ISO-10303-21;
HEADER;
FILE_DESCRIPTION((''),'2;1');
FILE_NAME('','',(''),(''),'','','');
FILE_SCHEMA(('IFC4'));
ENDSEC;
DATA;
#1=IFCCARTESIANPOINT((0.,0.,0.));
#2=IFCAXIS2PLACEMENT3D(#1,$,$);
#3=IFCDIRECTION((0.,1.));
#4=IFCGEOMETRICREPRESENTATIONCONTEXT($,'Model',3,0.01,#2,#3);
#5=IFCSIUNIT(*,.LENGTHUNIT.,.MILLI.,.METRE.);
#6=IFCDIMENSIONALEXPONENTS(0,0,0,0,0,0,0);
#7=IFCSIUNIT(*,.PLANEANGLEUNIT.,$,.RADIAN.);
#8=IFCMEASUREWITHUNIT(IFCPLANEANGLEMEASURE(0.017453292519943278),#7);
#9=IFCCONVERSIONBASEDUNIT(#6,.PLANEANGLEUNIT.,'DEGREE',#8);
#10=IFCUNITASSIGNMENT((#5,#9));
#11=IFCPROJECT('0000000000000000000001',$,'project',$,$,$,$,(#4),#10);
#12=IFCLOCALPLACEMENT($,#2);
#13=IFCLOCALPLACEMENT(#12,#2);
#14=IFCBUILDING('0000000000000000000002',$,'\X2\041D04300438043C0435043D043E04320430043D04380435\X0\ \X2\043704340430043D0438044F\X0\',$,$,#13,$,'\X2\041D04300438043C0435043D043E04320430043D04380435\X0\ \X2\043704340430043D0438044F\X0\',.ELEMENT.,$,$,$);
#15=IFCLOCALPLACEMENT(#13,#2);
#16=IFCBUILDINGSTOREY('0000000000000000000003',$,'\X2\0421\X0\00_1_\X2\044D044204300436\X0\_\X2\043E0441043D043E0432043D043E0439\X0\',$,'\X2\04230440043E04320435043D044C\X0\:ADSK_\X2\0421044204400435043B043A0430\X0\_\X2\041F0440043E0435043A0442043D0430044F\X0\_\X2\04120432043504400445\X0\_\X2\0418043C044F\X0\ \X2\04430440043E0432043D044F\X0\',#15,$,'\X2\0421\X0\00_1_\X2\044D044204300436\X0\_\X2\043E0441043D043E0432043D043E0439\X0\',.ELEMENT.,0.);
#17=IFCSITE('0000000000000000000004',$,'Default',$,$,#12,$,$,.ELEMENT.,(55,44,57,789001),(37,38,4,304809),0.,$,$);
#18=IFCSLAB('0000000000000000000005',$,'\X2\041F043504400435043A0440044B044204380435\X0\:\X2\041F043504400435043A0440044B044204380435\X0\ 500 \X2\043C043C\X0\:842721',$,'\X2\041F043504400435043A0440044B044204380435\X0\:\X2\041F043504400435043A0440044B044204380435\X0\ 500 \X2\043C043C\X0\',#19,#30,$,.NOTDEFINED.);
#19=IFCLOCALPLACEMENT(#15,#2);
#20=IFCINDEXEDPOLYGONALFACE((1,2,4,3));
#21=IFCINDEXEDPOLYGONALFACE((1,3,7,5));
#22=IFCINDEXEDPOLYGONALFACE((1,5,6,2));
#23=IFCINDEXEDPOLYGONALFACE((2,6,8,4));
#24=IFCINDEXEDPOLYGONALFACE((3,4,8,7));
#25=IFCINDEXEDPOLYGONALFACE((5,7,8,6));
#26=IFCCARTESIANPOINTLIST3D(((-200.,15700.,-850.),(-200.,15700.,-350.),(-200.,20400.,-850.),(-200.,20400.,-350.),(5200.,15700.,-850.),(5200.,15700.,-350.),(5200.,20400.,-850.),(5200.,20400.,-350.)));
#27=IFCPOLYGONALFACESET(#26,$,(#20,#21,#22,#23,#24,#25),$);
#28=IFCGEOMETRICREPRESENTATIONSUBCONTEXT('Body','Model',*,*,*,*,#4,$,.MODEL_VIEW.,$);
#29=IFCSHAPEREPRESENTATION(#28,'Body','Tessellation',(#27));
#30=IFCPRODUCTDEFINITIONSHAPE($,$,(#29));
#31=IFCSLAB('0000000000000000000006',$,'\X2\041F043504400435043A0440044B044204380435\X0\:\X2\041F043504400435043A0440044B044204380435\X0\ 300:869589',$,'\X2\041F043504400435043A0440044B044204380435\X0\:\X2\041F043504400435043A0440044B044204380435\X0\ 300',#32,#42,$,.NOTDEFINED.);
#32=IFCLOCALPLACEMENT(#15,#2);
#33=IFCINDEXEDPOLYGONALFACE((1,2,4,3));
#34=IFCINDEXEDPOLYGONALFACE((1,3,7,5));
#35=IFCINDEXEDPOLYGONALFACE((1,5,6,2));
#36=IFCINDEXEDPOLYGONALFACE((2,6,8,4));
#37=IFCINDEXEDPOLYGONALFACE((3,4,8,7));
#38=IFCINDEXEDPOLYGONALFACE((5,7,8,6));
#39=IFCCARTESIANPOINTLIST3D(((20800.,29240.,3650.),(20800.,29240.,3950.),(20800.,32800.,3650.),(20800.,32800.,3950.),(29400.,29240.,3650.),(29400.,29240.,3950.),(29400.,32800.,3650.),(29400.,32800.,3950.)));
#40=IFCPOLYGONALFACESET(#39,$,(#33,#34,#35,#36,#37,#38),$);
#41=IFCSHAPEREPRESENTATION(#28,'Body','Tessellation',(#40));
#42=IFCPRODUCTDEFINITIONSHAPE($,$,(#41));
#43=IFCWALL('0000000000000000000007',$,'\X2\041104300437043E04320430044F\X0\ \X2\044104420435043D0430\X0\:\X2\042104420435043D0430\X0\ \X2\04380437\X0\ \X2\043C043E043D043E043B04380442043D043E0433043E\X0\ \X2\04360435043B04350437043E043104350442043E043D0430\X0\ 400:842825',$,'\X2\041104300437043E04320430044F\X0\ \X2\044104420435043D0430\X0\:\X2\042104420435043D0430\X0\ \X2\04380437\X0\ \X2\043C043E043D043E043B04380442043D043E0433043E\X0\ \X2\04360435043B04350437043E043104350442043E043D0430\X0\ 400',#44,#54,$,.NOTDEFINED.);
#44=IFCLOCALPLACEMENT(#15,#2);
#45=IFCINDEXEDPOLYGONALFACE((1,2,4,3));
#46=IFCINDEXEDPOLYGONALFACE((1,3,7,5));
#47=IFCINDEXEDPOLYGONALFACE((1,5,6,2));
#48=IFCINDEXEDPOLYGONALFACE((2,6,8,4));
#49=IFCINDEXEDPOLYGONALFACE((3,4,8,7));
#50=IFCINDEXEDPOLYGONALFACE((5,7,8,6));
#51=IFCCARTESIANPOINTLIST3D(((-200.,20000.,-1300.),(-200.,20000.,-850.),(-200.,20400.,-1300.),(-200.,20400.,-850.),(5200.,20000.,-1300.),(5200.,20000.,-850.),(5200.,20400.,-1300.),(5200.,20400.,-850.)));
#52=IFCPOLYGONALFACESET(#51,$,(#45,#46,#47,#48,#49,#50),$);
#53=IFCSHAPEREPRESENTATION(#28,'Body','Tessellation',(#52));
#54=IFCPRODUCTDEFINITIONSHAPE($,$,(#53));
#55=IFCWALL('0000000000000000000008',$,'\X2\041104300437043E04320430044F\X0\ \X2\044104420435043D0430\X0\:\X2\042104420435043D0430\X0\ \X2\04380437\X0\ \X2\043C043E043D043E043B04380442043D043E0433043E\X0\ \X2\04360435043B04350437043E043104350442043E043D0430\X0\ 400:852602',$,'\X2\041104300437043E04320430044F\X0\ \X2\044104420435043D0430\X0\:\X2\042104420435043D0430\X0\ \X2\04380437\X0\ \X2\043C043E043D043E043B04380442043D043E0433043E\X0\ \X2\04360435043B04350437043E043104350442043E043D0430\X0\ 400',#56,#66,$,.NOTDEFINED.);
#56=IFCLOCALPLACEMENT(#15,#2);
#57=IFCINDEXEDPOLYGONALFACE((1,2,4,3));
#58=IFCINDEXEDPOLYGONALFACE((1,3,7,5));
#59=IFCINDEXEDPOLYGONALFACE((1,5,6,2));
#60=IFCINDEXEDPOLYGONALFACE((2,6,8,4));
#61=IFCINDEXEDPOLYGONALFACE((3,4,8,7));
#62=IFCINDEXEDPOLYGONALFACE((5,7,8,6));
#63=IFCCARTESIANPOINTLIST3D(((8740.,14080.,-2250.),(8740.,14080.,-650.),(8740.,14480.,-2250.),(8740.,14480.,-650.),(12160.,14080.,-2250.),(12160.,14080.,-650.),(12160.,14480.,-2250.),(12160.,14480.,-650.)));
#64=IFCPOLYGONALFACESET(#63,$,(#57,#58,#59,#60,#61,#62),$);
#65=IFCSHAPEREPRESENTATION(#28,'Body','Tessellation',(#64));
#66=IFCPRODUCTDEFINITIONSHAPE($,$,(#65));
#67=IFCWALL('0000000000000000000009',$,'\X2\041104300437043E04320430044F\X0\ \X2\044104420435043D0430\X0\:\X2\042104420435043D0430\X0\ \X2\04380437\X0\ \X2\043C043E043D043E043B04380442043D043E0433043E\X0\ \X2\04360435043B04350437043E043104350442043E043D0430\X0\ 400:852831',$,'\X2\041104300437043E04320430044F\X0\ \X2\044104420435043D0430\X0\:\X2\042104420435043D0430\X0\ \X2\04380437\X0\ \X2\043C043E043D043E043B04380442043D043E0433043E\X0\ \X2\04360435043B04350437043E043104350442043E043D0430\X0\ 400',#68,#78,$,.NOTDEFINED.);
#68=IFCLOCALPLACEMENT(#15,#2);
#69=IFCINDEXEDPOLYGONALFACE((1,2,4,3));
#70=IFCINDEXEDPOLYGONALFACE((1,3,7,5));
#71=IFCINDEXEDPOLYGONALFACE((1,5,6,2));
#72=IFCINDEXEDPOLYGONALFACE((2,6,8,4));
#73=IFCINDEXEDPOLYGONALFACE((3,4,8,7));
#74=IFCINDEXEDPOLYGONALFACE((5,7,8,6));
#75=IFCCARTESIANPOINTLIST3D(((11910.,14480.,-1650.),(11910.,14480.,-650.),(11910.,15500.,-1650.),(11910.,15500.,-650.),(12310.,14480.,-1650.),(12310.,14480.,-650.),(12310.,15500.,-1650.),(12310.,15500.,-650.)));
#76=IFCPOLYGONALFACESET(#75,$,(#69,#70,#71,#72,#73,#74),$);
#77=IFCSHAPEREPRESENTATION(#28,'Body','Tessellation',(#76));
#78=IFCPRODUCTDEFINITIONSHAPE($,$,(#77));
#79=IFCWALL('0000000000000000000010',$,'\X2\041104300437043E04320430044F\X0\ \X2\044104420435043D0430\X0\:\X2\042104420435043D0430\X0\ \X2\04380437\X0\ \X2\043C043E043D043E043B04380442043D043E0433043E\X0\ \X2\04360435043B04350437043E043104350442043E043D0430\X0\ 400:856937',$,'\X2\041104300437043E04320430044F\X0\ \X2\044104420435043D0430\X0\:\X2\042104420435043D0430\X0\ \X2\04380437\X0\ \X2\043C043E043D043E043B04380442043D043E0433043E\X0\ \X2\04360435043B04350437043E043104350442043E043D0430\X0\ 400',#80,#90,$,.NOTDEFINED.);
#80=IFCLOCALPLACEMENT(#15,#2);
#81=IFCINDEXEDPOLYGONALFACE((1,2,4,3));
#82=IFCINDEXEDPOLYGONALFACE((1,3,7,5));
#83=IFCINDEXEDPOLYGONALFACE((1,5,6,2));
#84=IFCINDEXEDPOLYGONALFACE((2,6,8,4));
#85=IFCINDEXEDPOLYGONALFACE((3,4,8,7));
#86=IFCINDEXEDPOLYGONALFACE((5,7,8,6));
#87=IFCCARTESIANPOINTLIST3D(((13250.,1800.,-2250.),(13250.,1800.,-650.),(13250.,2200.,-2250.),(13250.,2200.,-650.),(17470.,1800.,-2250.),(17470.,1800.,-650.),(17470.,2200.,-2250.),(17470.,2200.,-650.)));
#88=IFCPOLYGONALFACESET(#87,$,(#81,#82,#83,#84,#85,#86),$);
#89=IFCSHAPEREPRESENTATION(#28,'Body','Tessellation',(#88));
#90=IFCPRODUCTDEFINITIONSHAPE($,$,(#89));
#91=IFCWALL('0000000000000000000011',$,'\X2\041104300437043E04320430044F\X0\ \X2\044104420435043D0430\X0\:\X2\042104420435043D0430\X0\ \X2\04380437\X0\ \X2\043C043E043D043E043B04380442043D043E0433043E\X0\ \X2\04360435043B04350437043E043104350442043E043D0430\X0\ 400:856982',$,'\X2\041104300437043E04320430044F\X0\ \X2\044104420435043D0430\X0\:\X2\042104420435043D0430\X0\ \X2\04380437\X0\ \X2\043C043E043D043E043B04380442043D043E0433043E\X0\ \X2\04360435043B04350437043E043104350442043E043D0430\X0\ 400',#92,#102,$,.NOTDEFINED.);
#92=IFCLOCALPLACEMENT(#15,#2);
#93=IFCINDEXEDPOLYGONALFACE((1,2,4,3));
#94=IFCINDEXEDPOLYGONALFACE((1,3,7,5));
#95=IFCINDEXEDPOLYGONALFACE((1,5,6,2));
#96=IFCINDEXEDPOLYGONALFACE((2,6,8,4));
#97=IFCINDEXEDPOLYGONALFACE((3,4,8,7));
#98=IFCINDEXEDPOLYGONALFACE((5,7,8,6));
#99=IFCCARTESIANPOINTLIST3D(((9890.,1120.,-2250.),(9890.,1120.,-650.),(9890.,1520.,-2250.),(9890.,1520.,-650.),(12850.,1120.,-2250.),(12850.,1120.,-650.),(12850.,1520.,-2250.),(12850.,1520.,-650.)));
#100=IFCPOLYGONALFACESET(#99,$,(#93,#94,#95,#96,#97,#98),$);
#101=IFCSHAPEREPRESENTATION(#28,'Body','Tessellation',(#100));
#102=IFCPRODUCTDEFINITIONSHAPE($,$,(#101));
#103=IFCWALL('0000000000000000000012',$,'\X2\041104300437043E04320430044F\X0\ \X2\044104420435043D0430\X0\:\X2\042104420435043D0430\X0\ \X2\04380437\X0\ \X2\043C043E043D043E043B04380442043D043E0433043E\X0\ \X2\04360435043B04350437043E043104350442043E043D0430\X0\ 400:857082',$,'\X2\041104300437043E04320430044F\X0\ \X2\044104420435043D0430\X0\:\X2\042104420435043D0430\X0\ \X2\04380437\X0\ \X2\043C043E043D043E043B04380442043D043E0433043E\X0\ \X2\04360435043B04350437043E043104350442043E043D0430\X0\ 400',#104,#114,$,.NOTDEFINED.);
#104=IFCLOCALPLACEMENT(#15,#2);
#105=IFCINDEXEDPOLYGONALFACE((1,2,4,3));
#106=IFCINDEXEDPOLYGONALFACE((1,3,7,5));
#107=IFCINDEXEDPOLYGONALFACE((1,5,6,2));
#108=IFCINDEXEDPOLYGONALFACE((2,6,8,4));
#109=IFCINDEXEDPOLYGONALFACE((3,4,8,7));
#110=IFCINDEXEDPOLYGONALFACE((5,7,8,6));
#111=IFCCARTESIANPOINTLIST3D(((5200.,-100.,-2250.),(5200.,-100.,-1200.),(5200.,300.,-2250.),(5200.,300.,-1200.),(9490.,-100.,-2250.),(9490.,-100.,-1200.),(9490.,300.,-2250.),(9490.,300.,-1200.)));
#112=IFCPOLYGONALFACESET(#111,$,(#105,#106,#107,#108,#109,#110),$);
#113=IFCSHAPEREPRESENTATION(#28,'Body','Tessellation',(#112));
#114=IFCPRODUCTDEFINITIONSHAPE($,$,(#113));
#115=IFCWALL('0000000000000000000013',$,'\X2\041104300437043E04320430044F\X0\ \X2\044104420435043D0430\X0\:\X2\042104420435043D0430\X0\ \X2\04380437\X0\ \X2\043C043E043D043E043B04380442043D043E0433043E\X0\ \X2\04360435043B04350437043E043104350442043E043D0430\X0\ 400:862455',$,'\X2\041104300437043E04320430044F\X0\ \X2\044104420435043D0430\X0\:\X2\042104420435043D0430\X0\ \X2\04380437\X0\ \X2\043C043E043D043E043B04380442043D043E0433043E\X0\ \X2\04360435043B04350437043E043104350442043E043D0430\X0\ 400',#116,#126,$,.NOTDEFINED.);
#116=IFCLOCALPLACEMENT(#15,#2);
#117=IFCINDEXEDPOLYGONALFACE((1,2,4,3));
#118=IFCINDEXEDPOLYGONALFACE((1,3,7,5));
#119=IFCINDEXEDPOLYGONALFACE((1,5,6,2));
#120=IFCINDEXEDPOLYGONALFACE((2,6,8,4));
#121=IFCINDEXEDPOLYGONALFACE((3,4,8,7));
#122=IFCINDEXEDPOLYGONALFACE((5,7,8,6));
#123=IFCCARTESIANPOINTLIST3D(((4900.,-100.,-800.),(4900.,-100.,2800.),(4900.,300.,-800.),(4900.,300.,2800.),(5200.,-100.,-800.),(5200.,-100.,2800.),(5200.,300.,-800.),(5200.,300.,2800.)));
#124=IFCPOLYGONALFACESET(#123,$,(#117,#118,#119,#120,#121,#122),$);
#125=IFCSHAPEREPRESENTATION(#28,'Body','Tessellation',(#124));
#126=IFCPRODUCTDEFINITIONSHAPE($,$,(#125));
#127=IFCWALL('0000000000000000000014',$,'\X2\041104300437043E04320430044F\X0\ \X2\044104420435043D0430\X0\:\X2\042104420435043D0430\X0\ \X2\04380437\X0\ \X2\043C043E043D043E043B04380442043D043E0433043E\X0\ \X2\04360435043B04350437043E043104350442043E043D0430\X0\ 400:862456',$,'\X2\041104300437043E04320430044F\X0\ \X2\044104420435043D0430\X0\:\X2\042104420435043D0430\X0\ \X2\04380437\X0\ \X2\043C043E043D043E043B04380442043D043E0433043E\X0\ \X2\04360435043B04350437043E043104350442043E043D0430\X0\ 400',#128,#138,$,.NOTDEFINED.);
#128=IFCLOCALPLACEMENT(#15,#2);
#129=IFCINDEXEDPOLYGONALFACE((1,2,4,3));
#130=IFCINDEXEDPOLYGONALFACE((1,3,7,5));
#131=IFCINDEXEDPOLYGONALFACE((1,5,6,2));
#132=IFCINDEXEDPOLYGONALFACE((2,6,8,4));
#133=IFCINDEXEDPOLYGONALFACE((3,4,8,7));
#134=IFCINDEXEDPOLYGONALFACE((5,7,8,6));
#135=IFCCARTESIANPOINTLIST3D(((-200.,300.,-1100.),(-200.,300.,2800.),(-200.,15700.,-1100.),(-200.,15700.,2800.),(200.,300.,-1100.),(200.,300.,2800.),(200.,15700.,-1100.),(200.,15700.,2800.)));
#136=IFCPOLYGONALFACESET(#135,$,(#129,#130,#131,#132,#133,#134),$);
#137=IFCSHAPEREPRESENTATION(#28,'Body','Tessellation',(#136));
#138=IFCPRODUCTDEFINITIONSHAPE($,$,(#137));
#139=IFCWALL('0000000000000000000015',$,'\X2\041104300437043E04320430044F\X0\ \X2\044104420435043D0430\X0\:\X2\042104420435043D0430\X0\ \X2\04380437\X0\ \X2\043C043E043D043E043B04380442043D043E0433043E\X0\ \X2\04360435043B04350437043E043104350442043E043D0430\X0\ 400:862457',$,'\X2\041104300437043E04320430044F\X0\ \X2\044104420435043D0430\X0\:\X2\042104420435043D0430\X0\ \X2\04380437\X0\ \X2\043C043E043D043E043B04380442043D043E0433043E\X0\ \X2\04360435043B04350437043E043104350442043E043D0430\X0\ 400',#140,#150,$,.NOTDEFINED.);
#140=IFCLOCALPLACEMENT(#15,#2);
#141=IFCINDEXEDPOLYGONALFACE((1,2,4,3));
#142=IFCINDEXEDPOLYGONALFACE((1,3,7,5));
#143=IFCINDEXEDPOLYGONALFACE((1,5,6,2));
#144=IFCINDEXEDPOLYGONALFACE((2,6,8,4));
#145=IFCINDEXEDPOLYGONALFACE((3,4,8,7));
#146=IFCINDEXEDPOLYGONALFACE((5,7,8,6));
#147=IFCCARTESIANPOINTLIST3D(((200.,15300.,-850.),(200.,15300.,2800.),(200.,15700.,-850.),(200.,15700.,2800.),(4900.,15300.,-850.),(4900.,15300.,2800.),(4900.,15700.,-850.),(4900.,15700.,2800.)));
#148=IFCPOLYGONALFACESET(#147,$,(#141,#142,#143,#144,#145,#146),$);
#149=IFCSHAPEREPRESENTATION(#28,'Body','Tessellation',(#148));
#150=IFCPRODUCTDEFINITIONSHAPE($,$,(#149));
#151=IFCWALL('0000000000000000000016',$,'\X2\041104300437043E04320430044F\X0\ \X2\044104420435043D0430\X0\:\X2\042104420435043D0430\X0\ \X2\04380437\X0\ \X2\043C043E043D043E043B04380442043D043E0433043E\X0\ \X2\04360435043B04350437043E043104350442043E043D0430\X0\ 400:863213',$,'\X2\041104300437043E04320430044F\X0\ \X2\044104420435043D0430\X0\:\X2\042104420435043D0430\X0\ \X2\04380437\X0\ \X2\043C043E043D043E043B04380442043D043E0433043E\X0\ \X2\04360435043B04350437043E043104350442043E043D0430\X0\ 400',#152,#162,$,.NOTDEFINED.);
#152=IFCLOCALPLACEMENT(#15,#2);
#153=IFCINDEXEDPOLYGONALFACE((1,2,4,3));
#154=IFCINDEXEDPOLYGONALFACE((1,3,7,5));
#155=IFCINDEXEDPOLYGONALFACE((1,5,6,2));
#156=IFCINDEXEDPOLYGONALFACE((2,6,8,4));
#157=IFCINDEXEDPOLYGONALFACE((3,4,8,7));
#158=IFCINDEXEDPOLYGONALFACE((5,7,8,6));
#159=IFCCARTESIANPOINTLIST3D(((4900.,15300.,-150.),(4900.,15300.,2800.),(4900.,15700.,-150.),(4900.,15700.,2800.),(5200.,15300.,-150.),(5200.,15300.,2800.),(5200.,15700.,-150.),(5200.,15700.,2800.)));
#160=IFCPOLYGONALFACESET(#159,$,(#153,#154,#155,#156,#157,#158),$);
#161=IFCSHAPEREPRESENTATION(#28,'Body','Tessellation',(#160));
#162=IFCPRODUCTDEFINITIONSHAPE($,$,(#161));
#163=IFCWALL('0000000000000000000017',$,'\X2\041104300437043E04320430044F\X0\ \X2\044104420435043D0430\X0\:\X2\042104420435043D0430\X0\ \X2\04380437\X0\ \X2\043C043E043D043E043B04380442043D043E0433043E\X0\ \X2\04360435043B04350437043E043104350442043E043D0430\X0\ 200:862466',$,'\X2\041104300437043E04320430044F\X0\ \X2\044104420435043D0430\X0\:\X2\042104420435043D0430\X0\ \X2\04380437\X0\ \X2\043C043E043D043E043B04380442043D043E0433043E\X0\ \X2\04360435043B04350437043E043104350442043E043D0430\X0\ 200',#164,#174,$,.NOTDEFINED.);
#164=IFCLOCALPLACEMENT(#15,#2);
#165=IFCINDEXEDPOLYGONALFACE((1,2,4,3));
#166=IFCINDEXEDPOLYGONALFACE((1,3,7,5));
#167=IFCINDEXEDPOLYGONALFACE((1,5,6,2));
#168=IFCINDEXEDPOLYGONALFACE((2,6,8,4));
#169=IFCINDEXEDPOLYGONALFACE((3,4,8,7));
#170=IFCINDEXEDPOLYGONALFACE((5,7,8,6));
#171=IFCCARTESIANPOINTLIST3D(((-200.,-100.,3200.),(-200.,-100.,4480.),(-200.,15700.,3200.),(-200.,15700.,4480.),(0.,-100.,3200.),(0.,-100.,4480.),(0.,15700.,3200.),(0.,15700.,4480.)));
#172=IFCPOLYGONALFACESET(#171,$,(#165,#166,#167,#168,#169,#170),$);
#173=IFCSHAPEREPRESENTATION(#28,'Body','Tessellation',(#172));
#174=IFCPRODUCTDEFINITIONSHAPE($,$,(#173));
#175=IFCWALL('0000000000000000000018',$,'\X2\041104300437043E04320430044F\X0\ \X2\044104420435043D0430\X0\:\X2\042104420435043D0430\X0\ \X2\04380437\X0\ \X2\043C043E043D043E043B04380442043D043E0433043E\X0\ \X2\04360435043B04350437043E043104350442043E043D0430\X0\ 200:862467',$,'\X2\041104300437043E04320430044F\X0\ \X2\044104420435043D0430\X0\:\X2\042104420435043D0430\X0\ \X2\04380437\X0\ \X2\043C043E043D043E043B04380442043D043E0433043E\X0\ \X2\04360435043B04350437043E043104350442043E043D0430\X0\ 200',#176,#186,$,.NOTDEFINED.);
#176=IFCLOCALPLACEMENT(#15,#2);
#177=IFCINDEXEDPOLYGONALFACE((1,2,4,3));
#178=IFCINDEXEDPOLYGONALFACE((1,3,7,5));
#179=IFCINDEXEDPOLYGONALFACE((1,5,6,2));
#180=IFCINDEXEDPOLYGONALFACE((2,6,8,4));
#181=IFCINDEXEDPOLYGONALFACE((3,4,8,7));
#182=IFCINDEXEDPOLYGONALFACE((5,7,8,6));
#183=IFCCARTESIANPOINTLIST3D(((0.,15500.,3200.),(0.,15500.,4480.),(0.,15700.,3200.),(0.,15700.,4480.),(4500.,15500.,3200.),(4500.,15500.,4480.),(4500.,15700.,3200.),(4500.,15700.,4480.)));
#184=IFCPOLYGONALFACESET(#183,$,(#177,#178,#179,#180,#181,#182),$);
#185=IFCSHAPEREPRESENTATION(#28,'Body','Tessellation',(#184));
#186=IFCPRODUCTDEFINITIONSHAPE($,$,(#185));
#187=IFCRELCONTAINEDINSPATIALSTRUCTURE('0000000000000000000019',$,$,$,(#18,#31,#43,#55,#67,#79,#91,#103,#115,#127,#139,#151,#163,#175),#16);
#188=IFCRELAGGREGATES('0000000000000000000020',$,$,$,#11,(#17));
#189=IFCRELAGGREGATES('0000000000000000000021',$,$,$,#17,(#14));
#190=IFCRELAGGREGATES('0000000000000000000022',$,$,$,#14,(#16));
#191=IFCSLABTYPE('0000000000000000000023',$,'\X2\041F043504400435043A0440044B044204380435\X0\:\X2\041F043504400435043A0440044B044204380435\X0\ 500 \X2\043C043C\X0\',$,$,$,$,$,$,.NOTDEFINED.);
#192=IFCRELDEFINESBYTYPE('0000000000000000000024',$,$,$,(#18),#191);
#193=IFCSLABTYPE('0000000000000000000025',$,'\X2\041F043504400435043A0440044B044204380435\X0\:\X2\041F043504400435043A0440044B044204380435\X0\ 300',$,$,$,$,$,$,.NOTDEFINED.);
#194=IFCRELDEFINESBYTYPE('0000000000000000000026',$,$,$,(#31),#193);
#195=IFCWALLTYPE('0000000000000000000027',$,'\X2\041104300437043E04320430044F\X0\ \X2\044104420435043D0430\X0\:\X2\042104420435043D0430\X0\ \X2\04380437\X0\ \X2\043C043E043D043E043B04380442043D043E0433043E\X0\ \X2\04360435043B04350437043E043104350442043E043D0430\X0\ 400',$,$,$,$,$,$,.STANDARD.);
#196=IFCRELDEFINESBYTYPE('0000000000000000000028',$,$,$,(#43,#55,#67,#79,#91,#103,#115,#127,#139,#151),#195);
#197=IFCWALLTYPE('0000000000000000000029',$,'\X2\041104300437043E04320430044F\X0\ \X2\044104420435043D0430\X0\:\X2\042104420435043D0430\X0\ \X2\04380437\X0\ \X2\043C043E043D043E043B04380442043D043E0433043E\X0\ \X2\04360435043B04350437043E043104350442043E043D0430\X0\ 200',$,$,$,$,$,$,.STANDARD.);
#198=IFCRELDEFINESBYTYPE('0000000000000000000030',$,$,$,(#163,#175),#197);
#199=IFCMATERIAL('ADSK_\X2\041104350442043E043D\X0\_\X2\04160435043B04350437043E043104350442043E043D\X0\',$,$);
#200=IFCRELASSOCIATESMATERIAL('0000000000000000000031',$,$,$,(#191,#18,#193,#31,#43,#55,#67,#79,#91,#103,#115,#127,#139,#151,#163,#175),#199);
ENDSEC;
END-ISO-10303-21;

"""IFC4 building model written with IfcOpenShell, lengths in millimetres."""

from ifc_helpers import new_model, entity, si_unit, converted_unit, direction, frame, origin, place, context, subcontext, project, spatial, indexed_curve, outline, extrude, material, type_object, element, save


model = new_model("IFC4")

# Units and contexts
model_context = context("Model", 3, precision=0.01, world=origin(), true_north=direction((0.0, 1.0)))
body_context = subcontext(model_context, "Body", "Model", "MODEL_VIEW")
ifc_project = project(units=[si_unit("LENGTHUNIT", "METRE", prefix="MILLI"), converted_unit("PLANEANGLEUNIT", "DEGREE", entity("IfcPlaneAngleMeasure", 0.017453292519943278), si_unit("PLANEANGLEUNIT", "RADIAN"), dimensions=[0, 0, 0, 0, 0, 0, 0])], contexts=[model_context])

# Site, building, storey
site_placement = place(None, origin())
site = spatial("IfcSite", under=ifc_project, at=site_placement, Name="Default", CompositionType="ELEMENT", RefLatitude=(55, 44, 57, 789001), RefLongitude=(37, 38, 4, 304809), RefElevation=0.0)
building_placement = place(site_placement, origin())
building = spatial("IfcBuilding", under=site, at=building_placement, Name="Наименование здания", LongName="Наименование здания", CompositionType="ELEMENT")
storey_placement = place(building_placement, origin())
storey = spatial("IfcBuildingStorey", under=building, at=storey_placement, Name="С00_1_этаж_основной", ObjectType="Уровень:ADSK_Стрелка_Проектная_Вверх_Имя уровня", LongName="С00_1_этаж_основной", CompositionType="ELEMENT", Elevation=0.0)

# Slabs
ifc_material_1 = material(Name="ADSK_Бетон_Железобетон")
slab_type_1 = type_object("IfcSlabType", Name="Перекрытие:Перекрытие 500 мм", PredefinedType="NOTDEFINED", material=ifc_material_1)
slab_1_placement = place(storey_placement, origin())
element("IfcSlab", 1, at=slab_1_placement, inside=storey, type_object=slab_type_1, material=ifc_material_1, Name="Перекрытие:Перекрытие 500 мм:842721", ObjectType="Перекрытие:Перекрытие 500 мм", PredefinedType="NOTDEFINED", context=body_context, shape_type="SweptSolid", body=[
    extrude(outline(indexed_curve([(-2350.0, -2700.0), (2350.0, -2700.0), (2350.0, 2700.0), (-2350.0, 2700.0), (-2350.0, -2700.0)], self_intersect=False)), frame((2500.0, 18050.0, -350.0), z_axis=(0.0, 0.0, -1.0), x_axis=(0.0, 1.0, 0.0)), (0.0, 0.0, 1.0), 500.0),
])
slab_type_2 = type_object("IfcSlabType", Name="Перекрытие:Перекрытие 300", PredefinedType="NOTDEFINED", material=ifc_material_1)
slab_2_placement = place(storey_placement, origin())
element("IfcSlab", 2, at=slab_2_placement, inside=storey, type_object=slab_type_2, material=ifc_material_1, Name="Перекрытие:Перекрытие 300:869589", ObjectType="Перекрытие:Перекрытие 300", PredefinedType="NOTDEFINED", context=body_context, shape_type="SweptSolid", body=[
    extrude(outline(indexed_curve([(-1780.0, -4300.0), (1780.0, -4300.0), (1780.0, 4300.0), (-1780.0, 4300.0), (-1780.0, -4300.0)], self_intersect=False)), frame((25100.0, 31020.0, 3950.0), z_axis=(0.0, 0.0, -1.0), x_axis=(0.0, 1.0, 0.0)), (0.0, 0.0, 1.0), 300.0),
])

# Walls
wall_type_1 = type_object("IfcWallType", Name="Базовая стена:Стена из монолитного железобетона 400", PredefinedType="STANDARD")
wall_1_placement = place(storey_placement, frame((-200.0, 20200.0, -1300.0)))
element("IfcWall", 3, at=wall_1_placement, inside=storey, type_object=wall_type_1, material=ifc_material_1, Name="Базовая стена:Стена из монолитного железобетона 400:842825", ObjectType="Базовая стена:Стена из монолитного железобетона 400", PredefinedType="NOTDEFINED", context=body_context, shape_type="SweptSolid", body=[
    extrude(outline(indexed_curve([(5400.0, 200.0), (0.0, 200.0), (0.0, -200.0), (5400.0, -200.0), (5400.0, 200.0)], self_intersect=False)), origin(), (0.0, 0.0, 1.0), 450.0),
])
wall_2_placement = place(storey_placement, frame((12160.0, 14280.0, -2250.0), z_axis=(0.0, 0.0, 1.0), x_axis=(-1.0, 0.0, 0.0)))
element("IfcWall", 4, at=wall_2_placement, inside=storey, type_object=wall_type_1, material=ifc_material_1, Name="Базовая стена:Стена из монолитного железобетона 400:852602", ObjectType="Базовая стена:Стена из монолитного железобетона 400", PredefinedType="NOTDEFINED", context=body_context, shape_type="SweptSolid", body=[
    extrude(outline(indexed_curve([(3420.0, 200.0), (0.0, 200.0), (0.0, -200.0), (3420.0, -200.0), (3420.0, 200.0)], self_intersect=False)), origin(), (0.0, 0.0, 1.0), 1600.0),
])
wall_3_placement = place(storey_placement, frame((12110.0, 14480.0, -1650.0), z_axis=(0.0, 0.0, 1.0), x_axis=(0.0, 1.0, 0.0)))
element("IfcWall", 5, at=wall_3_placement, inside=storey, type_object=wall_type_1, material=ifc_material_1, Name="Базовая стена:Стена из монолитного железобетона 400:852831", ObjectType="Базовая стена:Стена из монолитного железобетона 400", PredefinedType="NOTDEFINED", context=body_context, shape_type="SweptSolid", body=[
    extrude(outline(indexed_curve([(1020.0, 200.0), (0.0, 200.0), (0.0, -200.0), (1020.0, -200.0), (1020.0, 200.0)], self_intersect=False)), origin(), (0.0, 0.0, 1.0), 1000.0),
])
wall_4_placement = place(storey_placement, frame((17470.0, 2000.0, -2250.0), z_axis=(0.0, 0.0, 1.0), x_axis=(-1.0, 0.0, 0.0)))
element("IfcWall", 6, at=wall_4_placement, inside=storey, type_object=wall_type_1, material=ifc_material_1, Name="Базовая стена:Стена из монолитного железобетона 400:856937", ObjectType="Базовая стена:Стена из монолитного железобетона 400", PredefinedType="NOTDEFINED", context=body_context, shape_type="SweptSolid", body=[
    extrude(outline(indexed_curve([(4220.0, 200.0), (0.0, 200.0), (0.0, -200.0), (4220.0, -200.0), (4220.0, 200.0)], self_intersect=False)), origin(), (0.0, 0.0, 1.0), 1600.0),
])
wall_5_placement = place(storey_placement, frame((12850.0, 1320.0, -2250.0), z_axis=(0.0, 0.0, 1.0), x_axis=(-1.0, 0.0, 0.0)))
element("IfcWall", 7, at=wall_5_placement, inside=storey, type_object=wall_type_1, material=ifc_material_1, Name="Базовая стена:Стена из монолитного железобетона 400:856982", ObjectType="Базовая стена:Стена из монолитного железобетона 400", PredefinedType="NOTDEFINED", context=body_context, shape_type="SweptSolid", body=[
    extrude(outline(indexed_curve([(2960.0, 200.0), (0.0, 200.0), (0.0, -200.0), (2960.0, -200.0), (2960.0, 200.0)], self_intersect=False)), origin(), (0.0, 0.0, 1.0), 1600.0),
])
wall_6_placement = place(storey_placement, frame((9490.0, 100.0, -2250.0), z_axis=(0.0, 0.0, 1.0), x_axis=(-1.0, 0.0, 0.0)))
element("IfcWall", 8, at=wall_6_placement, inside=storey, type_object=wall_type_1, material=ifc_material_1, Name="Базовая стена:Стена из монолитного железобетона 400:857082", ObjectType="Базовая стена:Стена из монолитного железобетона 400", PredefinedType="NOTDEFINED", context=body_context, shape_type="SweptSolid", body=[
    extrude(outline(indexed_curve([(4290.0, 200.0), (0.0, 200.0), (0.0, -200.0), (4290.0, -200.0), (4290.0, 200.0)], self_intersect=False)), origin(), (0.0, 0.0, 1.0), 1050.0),
])
wall_7_placement = place(storey_placement, frame((5200.0, 100.0, -800.0), z_axis=(0.0, 0.0, 1.0), x_axis=(-1.0, 0.0, 0.0)))
element("IfcWall", 9, at=wall_7_placement, inside=storey, type_object=wall_type_1, material=ifc_material_1, Name="Базовая стена:Стена из монолитного железобетона 400:862455", ObjectType="Базовая стена:Стена из монолитного железобетона 400", PredefinedType="NOTDEFINED", context=body_context, shape_type="SweptSolid", body=[
    extrude(outline(indexed_curve([(300.0, 200.0), (0.0, 200.0), (0.0, -200.0), (300.0, -200.0), (300.0, 200.0)], self_intersect=False)), origin(), (0.0, 0.0, 1.0), 3600.0),
])
wall_8_placement = place(storey_placement, frame((0.0, 300.0, -1100.0), z_axis=(0.0, 0.0, 1.0), x_axis=(0.0, 1.0, 0.0)))
element("IfcWall", 10, at=wall_8_placement, inside=storey, type_object=wall_type_1, material=ifc_material_1, Name="Базовая стена:Стена из монолитного железобетона 400:862456", ObjectType="Базовая стена:Стена из монолитного железобетона 400", PredefinedType="NOTDEFINED", context=body_context, shape_type="SweptSolid", body=[
    extrude(outline(indexed_curve([(15400.0, 200.0), (0.0, 200.0), (0.0, -200.0), (15400.0, -200.0), (15400.0, 200.0)], self_intersect=False)), origin(), (0.0, 0.0, 1.0), 3900.0),
])
wall_9_placement = place(storey_placement, frame((200.0, 15500.0, -850.0)))
element("IfcWall", 11, at=wall_9_placement, inside=storey, type_object=wall_type_1, material=ifc_material_1, Name="Базовая стена:Стена из монолитного железобетона 400:862457", ObjectType="Базовая стена:Стена из монолитного железобетона 400", PredefinedType="NOTDEFINED", context=body_context, shape_type="SweptSolid", body=[
    extrude(outline(indexed_curve([(4700.0, 200.0), (0.0, 200.0), (0.0, -200.0), (4700.0, -200.0), (4700.0, 200.0)], self_intersect=False)), origin(), (0.0, 0.0, 1.0), 3650.0),
])
wall_10_placement = place(storey_placement, frame((4900.0, 15500.0, -150.0)))
element("IfcWall", 12, at=wall_10_placement, inside=storey, type_object=wall_type_1, material=ifc_material_1, Name="Базовая стена:Стена из монолитного железобетона 400:863213", ObjectType="Базовая стена:Стена из монолитного железобетона 400", PredefinedType="NOTDEFINED", context=body_context, shape_type="SweptSolid", body=[
    extrude(outline(indexed_curve([(300.0, 200.0), (0.0, 200.0), (0.0, -200.0), (300.0, -200.0), (300.0, 200.0)], self_intersect=False)), origin(), (0.0, 0.0, 1.0), 2950.0),
])
wall_type_2 = type_object("IfcWallType", Name="Базовая стена:Стена из монолитного железобетона 200", PredefinedType="STANDARD")
wall_11_placement = place(storey_placement, frame((-100.0, -100.0, 3200.0), z_axis=(0.0, 0.0, 1.0), x_axis=(0.0, 1.0, 0.0)))
element("IfcWall", 13, at=wall_11_placement, inside=storey, type_object=wall_type_2, material=ifc_material_1, Name="Базовая стена:Стена из монолитного железобетона 200:862466", ObjectType="Базовая стена:Стена из монолитного железобетона 200", PredefinedType="NOTDEFINED", context=body_context, shape_type="SweptSolid", body=[
    extrude(outline(indexed_curve([(15800.0, 100.0), (0.0, 100.0), (0.0, -100.0), (15800.0, -100.0), (15800.0, 100.0)], self_intersect=False)), origin(), (0.0, 0.0, 1.0), 1280.0),
])
wall_12_placement = place(storey_placement, frame((0.0, 15600.0, 3200.0)))
element("IfcWall", 14, at=wall_12_placement, inside=storey, type_object=wall_type_2, material=ifc_material_1, Name="Базовая стена:Стена из монолитного железобетона 200:862467", ObjectType="Базовая стена:Стена из монолитного железобетона 200", PredefinedType="NOTDEFINED", context=body_context, shape_type="SweptSolid", body=[
    extrude(outline(indexed_curve([(4500.0, 100.0), (0.0, 100.0), (0.0, -100.0), (4500.0, -100.0), (4500.0, 100.0)], self_intersect=False)), origin(), (0.0, 0.0, 1.0), 1280.0),
])

save(model, "model.ifc")
